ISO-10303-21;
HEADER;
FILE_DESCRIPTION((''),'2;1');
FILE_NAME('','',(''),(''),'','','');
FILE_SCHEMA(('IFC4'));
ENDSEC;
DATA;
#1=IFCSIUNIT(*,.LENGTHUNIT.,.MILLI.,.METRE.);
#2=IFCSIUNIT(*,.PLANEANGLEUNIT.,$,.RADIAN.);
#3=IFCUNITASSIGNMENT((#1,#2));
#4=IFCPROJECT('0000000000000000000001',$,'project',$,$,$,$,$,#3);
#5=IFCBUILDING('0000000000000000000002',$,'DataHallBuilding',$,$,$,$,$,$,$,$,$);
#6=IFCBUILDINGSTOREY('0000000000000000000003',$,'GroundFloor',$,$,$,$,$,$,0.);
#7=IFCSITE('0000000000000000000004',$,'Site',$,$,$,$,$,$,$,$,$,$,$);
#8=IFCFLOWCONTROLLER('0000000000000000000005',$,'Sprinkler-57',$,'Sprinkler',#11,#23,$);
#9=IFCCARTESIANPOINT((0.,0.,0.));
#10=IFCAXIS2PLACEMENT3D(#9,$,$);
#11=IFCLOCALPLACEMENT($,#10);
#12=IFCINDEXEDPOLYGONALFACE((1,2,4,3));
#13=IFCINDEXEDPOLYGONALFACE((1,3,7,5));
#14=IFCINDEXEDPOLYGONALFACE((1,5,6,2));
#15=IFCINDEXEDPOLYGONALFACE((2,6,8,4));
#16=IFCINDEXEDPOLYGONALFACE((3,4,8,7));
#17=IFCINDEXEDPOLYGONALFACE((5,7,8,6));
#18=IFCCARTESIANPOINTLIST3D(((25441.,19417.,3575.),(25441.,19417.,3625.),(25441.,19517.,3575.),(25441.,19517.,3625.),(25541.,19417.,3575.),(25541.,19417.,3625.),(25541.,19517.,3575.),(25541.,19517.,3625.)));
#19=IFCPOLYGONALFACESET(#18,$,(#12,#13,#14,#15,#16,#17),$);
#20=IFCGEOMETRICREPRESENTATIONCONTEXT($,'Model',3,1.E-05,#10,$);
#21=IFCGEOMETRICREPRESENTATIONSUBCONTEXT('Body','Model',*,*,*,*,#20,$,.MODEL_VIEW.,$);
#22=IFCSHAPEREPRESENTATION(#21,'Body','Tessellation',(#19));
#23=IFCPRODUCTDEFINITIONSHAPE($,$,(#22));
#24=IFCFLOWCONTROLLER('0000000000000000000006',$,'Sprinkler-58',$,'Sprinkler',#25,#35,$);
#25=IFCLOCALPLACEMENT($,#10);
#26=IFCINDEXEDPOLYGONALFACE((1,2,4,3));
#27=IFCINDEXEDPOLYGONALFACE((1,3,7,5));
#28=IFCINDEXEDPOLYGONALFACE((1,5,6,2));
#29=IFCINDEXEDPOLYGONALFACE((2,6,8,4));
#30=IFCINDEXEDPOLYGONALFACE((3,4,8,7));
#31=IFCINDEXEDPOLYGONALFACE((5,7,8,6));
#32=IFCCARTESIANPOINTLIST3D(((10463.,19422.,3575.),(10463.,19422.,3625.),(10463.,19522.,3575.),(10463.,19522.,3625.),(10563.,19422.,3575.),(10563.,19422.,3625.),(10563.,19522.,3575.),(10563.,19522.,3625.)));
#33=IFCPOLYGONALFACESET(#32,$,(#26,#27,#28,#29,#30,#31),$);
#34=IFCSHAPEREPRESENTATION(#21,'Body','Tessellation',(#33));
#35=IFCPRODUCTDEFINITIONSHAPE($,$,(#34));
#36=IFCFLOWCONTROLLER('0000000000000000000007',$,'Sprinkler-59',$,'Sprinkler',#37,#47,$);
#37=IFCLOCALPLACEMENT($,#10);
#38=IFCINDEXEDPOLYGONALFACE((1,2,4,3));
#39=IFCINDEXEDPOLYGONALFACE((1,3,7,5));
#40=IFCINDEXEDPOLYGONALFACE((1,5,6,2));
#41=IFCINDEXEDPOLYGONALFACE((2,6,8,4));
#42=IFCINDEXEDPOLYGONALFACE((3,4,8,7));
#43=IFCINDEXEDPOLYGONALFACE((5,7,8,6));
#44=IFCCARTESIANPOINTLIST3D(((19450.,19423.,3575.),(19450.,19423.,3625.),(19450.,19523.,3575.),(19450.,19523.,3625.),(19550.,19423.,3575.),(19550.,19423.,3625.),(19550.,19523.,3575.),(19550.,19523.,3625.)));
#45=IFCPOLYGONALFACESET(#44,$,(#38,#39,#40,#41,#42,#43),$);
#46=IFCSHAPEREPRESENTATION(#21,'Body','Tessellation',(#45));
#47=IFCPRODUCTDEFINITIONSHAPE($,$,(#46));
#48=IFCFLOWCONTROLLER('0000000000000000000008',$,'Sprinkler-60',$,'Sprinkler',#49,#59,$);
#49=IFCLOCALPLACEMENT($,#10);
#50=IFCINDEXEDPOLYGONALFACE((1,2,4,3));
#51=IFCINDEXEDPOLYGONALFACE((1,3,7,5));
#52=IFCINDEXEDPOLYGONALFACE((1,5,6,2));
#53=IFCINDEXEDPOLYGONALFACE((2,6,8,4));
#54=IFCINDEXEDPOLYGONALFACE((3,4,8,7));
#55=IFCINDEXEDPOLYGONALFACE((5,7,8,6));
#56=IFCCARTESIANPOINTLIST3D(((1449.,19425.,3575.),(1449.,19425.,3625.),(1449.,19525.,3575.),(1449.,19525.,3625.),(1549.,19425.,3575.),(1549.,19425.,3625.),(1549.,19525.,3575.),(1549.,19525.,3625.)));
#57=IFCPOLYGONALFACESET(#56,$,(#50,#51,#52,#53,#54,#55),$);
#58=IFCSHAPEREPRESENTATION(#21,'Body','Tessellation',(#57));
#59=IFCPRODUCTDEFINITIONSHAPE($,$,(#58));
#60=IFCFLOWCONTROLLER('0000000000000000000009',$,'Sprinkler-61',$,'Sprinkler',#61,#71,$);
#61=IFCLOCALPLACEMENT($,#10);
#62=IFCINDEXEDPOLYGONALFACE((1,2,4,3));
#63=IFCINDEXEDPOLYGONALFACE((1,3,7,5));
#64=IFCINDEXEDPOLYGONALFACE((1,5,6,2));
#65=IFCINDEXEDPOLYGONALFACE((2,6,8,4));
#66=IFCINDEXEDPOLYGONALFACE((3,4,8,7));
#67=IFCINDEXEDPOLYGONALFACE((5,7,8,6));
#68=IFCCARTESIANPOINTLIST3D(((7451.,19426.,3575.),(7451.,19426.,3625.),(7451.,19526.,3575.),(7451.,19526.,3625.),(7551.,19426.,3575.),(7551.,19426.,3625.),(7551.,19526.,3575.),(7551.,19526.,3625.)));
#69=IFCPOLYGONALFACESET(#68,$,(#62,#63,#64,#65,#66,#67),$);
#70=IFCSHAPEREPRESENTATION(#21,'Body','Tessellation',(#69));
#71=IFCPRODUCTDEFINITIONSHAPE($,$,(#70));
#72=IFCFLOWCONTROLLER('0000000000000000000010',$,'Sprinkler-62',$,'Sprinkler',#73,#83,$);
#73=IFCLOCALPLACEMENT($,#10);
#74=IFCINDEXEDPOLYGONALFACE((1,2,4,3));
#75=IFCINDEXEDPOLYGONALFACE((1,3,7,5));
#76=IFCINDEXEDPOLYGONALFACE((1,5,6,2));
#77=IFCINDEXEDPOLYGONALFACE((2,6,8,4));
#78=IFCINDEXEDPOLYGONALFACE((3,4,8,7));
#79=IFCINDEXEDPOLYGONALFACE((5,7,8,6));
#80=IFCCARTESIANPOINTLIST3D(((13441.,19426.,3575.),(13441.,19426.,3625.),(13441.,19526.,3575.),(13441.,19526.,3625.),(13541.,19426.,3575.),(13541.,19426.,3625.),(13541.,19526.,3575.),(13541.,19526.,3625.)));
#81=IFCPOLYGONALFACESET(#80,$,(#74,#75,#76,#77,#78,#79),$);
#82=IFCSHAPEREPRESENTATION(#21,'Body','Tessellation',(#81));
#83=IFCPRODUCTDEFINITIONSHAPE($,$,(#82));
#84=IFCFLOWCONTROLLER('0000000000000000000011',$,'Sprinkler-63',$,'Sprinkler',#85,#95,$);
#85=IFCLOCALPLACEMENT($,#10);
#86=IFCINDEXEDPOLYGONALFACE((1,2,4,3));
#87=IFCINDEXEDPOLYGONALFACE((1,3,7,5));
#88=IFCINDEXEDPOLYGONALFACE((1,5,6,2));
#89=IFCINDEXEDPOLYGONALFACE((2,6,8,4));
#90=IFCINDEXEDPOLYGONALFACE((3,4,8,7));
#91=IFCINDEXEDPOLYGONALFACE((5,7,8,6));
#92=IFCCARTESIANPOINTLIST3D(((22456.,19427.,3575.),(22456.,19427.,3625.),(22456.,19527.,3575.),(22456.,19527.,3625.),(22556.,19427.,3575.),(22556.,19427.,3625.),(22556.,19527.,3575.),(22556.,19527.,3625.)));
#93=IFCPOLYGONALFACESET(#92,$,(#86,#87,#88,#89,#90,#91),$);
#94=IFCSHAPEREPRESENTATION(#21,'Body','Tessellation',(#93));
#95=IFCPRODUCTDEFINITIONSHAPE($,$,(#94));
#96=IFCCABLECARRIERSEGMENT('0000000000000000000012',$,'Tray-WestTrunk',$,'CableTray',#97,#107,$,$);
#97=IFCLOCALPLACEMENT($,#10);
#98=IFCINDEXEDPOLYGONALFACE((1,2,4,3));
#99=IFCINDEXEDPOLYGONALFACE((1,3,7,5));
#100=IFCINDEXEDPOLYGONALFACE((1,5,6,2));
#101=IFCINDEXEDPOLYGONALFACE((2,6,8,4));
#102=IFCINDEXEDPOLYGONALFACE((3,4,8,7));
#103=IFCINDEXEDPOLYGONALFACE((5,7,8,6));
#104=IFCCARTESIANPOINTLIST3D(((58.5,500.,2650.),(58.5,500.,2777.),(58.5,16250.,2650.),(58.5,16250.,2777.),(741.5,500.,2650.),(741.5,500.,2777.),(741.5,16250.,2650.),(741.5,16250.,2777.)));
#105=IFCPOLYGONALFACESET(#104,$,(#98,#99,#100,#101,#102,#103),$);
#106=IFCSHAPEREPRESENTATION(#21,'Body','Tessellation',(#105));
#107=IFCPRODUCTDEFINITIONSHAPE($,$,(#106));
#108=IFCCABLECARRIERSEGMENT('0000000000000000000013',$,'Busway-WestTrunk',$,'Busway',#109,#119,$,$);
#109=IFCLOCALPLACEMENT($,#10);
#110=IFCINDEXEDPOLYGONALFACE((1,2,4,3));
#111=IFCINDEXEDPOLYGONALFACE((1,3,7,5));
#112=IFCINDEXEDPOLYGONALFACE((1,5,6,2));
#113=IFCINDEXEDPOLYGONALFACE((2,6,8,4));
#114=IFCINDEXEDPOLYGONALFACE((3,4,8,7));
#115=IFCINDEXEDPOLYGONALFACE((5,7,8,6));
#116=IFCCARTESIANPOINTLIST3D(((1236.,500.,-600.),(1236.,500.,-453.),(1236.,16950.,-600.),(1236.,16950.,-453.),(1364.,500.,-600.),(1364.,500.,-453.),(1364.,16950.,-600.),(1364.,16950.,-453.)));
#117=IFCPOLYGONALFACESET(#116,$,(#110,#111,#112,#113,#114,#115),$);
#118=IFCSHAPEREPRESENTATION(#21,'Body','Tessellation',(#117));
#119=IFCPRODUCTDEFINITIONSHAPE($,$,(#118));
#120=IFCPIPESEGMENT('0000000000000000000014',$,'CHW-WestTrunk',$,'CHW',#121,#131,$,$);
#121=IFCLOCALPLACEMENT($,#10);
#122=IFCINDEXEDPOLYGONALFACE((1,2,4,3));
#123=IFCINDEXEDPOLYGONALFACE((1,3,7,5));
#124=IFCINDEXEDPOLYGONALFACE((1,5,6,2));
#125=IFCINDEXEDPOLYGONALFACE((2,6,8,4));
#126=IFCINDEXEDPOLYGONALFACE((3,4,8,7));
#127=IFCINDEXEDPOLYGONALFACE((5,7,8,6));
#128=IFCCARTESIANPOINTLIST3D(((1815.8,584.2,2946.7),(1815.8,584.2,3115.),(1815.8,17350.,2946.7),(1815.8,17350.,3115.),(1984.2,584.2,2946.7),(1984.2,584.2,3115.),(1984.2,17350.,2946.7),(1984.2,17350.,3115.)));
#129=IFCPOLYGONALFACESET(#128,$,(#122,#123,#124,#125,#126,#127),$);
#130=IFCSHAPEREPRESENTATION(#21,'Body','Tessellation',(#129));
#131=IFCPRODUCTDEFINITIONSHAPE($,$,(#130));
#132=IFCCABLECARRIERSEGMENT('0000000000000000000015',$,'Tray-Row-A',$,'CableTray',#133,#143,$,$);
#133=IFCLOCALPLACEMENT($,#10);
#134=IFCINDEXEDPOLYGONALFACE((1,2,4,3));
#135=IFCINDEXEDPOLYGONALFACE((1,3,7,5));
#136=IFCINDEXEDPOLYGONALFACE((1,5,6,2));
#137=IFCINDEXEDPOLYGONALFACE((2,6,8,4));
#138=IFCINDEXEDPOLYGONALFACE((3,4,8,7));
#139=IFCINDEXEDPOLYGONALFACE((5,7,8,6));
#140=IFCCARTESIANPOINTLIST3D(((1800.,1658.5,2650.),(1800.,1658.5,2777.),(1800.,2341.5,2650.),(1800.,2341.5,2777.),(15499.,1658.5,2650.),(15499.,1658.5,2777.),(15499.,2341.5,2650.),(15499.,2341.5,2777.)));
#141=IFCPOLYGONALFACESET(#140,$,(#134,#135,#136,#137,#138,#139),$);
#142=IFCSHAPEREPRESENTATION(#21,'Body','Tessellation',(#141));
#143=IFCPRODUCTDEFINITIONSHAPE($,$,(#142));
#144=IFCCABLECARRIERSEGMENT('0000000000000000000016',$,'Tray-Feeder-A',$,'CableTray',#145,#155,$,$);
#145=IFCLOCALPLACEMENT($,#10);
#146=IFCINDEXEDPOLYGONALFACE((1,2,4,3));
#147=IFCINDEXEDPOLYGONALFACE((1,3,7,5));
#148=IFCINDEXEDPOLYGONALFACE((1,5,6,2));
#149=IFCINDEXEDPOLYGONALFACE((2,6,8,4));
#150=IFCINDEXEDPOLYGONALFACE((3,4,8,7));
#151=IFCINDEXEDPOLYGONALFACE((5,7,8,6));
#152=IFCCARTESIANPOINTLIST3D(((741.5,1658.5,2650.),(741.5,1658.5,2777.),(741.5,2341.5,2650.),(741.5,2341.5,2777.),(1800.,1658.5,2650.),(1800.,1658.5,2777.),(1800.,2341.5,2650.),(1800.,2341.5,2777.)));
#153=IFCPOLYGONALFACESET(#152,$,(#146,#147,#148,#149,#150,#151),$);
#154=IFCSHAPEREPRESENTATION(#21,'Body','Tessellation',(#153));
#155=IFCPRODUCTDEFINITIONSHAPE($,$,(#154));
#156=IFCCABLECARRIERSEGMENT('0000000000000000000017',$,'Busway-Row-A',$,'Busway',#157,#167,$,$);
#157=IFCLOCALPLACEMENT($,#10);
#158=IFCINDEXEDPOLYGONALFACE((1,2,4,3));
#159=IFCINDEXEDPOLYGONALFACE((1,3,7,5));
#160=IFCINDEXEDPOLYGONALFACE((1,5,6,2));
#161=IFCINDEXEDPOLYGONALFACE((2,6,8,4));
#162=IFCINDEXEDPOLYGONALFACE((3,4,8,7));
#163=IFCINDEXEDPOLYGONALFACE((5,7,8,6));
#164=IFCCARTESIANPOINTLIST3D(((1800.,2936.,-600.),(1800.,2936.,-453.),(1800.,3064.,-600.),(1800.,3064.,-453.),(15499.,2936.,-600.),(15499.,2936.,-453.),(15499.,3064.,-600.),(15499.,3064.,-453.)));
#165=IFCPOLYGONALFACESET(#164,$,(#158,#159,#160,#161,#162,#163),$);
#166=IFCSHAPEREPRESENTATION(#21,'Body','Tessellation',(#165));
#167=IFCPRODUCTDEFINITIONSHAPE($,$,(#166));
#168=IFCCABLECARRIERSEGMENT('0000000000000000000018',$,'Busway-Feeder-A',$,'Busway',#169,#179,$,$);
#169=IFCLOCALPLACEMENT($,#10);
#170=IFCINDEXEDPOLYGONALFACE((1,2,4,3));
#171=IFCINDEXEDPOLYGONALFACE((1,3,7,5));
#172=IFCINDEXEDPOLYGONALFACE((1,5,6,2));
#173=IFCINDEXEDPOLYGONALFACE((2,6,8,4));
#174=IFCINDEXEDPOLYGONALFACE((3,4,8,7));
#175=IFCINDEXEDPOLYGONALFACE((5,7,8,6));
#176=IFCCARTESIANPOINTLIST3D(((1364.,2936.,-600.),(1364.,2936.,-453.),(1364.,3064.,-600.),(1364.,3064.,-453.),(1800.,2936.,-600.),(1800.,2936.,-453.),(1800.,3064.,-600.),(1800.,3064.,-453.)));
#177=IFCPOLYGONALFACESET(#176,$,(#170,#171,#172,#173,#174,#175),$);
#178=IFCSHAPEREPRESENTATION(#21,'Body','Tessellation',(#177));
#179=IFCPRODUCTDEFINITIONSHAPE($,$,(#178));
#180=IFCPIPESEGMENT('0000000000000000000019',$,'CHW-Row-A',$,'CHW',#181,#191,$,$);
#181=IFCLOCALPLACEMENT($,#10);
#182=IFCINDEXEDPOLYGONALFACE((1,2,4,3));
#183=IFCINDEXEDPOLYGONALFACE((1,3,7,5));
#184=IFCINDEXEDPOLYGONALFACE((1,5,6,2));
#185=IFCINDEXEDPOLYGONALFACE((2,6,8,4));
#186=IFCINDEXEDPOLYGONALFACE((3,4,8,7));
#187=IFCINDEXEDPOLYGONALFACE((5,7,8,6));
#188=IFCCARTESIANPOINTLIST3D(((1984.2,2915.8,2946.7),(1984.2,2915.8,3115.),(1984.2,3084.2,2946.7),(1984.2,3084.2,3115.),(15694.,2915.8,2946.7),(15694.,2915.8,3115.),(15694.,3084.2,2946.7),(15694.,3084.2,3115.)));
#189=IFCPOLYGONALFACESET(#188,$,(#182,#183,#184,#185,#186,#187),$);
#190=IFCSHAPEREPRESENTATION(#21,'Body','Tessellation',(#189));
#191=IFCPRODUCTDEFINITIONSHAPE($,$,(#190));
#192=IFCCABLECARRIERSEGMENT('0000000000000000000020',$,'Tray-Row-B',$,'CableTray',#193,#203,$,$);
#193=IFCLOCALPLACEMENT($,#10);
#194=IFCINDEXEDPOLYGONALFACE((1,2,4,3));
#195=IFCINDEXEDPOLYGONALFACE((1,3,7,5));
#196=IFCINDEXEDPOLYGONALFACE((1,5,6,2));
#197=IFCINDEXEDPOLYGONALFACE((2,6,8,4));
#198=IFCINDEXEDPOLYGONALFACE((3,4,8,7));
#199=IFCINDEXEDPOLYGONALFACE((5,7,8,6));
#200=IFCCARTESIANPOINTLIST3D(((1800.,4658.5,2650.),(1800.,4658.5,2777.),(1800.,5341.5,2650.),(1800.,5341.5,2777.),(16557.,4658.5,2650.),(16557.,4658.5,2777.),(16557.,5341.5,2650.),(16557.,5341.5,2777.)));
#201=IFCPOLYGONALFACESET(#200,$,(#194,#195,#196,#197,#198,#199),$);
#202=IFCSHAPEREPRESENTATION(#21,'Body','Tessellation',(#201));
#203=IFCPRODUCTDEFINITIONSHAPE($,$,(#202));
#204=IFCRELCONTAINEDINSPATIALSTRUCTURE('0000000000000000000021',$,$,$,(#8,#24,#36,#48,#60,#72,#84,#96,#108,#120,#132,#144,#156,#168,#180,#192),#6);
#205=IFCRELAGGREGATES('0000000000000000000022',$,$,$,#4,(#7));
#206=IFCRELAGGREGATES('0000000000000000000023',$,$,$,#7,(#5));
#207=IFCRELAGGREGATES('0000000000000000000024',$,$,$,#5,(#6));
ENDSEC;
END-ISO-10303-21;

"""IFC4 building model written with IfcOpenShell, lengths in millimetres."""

from ifc_helpers import new_model, si_unit, frame, origin, place, context, subcontext, project, spatial, rectangle, extrude, element, save


model = new_model("IFC4")

# Units and contexts
model_context = context("Model", 3, precision=1e-05, world=origin())
body_context = subcontext(model_context, "Body", "Model", "MODEL_VIEW")
ifc_project = project(units=[si_unit("LENGTHUNIT", "METRE", prefix="MILLI"), si_unit("PLANEANGLEUNIT", "RADIAN")])

# Site, building, storey
site = spatial("IfcSite", under=ifc_project, Name="Site")
building = spatial("IfcBuilding", under=site, Name="DataHallBuilding")
storey = spatial("IfcBuildingStorey", under=building, Name="GroundFloor", Elevation=0.0)

# Flow controllers
flow_controller_1_placement = place(None, origin())
element("IfcFlowController", 1, at=flow_controller_1_placement, inside=storey, Name="Sprinkler-57", ObjectType="Sprinkler", context=body_context, shape_type="SweptSolid", body=[
    extrude(rectangle(XDim=100.0, YDim=100.0), frame((25491.0, 19467.0, 3575.0), z_axis=(0.0, 0.0, 1.0), x_axis=(1.0, 0.0, 0.0)), (0.0, 0.0, 1.0), 50.0),
])
flow_controller_2_placement = place(None, origin())
element("IfcFlowController", 2, at=flow_controller_2_placement, inside=storey, Name="Sprinkler-58", ObjectType="Sprinkler", context=body_context, shape_type="SweptSolid", body=[
    extrude(rectangle(XDim=100.0, YDim=100.0), frame((10513.0, 19472.0, 3575.0), z_axis=(0.0, 0.0, 1.0), x_axis=(1.0, 0.0, 0.0)), (0.0, 0.0, 1.0), 50.0),
])
flow_controller_3_placement = place(None, origin())
element("IfcFlowController", 3, at=flow_controller_3_placement, inside=storey, Name="Sprinkler-59", ObjectType="Sprinkler", context=body_context, shape_type="SweptSolid", body=[
    extrude(rectangle(XDim=100.0, YDim=100.0), frame((19500.0, 19473.0, 3575.0), z_axis=(0.0, 0.0, 1.0), x_axis=(1.0, 0.0, 0.0)), (0.0, 0.0, 1.0), 50.0),
])
flow_controller_4_placement = place(None, origin())
element("IfcFlowController", 4, at=flow_controller_4_placement, inside=storey, Name="Sprinkler-60", ObjectType="Sprinkler", context=body_context, shape_type="SweptSolid", body=[
    extrude(rectangle(XDim=100.0, YDim=100.0), frame((1499.0, 19475.0, 3575.0), z_axis=(0.0, 0.0, 1.0), x_axis=(1.0, 0.0, 0.0)), (0.0, 0.0, 1.0), 50.0),
])
flow_controller_5_placement = place(None, origin())
element("IfcFlowController", 5, at=flow_controller_5_placement, inside=storey, Name="Sprinkler-61", ObjectType="Sprinkler", context=body_context, shape_type="SweptSolid", body=[
    extrude(rectangle(XDim=100.0, YDim=100.0), frame((7501.0, 19476.0, 3575.0), z_axis=(0.0, 0.0, 1.0), x_axis=(1.0, 0.0, 0.0)), (0.0, 0.0, 1.0), 50.0),
])
flow_controller_6_placement = place(None, origin())
element("IfcFlowController", 6, at=flow_controller_6_placement, inside=storey, Name="Sprinkler-62", ObjectType="Sprinkler", context=body_context, shape_type="SweptSolid", body=[
    extrude(rectangle(XDim=100.0, YDim=100.0), frame((13491.0, 19476.0, 3575.0), z_axis=(0.0, 0.0, 1.0), x_axis=(1.0, 0.0, 0.0)), (0.0, 0.0, 1.0), 50.0),
])
flow_controller_7_placement = place(None, origin())
element("IfcFlowController", 7, at=flow_controller_7_placement, inside=storey, Name="Sprinkler-63", ObjectType="Sprinkler", context=body_context, shape_type="SweptSolid", body=[
    extrude(rectangle(XDim=100.0, YDim=100.0), frame((22506.0, 19477.0, 3575.0), z_axis=(0.0, 0.0, 1.0), x_axis=(1.0, 0.0, 0.0)), (0.0, 0.0, 1.0), 50.0),
])

# Cable carrier segments
cable_carrier_segment_1_placement = place(None, origin())
element("IfcCableCarrierSegment", 8, at=cable_carrier_segment_1_placement, inside=storey, Name="Tray-WestTrunk", ObjectType="CableTray", context=body_context, shape_type="SweptSolid", body=[
    extrude(rectangle(XDim=683.0, YDim=15750.0), frame((400.0, 8375.0, 2650.0), z_axis=(0.0, 0.0, 1.0), x_axis=(1.0, 0.0, 0.0)), (0.0, 0.0, 1.0), 127.0),
])
cable_carrier_segment_2_placement = place(None, origin())
element("IfcCableCarrierSegment", 9, at=cable_carrier_segment_2_placement, inside=storey, Name="Busway-WestTrunk", ObjectType="Busway", context=body_context, shape_type="SweptSolid", body=[
    extrude(rectangle(XDim=128.0, YDim=16450.0), frame((1300.0, 8725.0, -600.0), z_axis=(0.0, 0.0, 1.0), x_axis=(1.0, 0.0, 0.0)), (0.0, 0.0, 1.0), 147.0),
])

# Pipe segment
pipe_segment_1_placement = place(None, origin())
element("IfcPipeSegment", 10, at=pipe_segment_1_placement, inside=storey, Name="CHW-WestTrunk", ObjectType="CHW", context=body_context, shape_type="SweptSolid", body=[
    extrude(rectangle(XDim=168.3, YDim=16765.8), frame((1900.0, 8967.1, 2946.7), z_axis=(0.0, 0.0, 1.0), x_axis=(1.0, 0.0, 0.0)), (0.0, 0.0, 1.0), 168.3),
])

# Cable carrier segments
cable_carrier_segment_3_placement = place(None, origin())
element("IfcCableCarrierSegment", 11, at=cable_carrier_segment_3_placement, inside=storey, Name="Tray-Row-A", ObjectType="CableTray", context=body_context, shape_type="SweptSolid", body=[
    extrude(rectangle(XDim=13699.0, YDim=683.0), frame((8649.5, 2000.0, 2650.0), z_axis=(0.0, 0.0, 1.0), x_axis=(1.0, 0.0, 0.0)), (0.0, 0.0, 1.0), 127.0),
])
cable_carrier_segment_4_placement = place(None, origin())
element("IfcCableCarrierSegment", 12, at=cable_carrier_segment_4_placement, inside=storey, Name="Tray-Feeder-A", ObjectType="CableTray", context=body_context, shape_type="SweptSolid", body=[
    extrude(rectangle(XDim=1058.5, YDim=683.0), frame((1270.8, 2000.0, 2650.0), z_axis=(0.0, 0.0, 1.0), x_axis=(1.0, 0.0, 0.0)), (0.0, 0.0, 1.0), 127.0),
])
cable_carrier_segment_5_placement = place(None, origin())
element("IfcCableCarrierSegment", 13, at=cable_carrier_segment_5_placement, inside=storey, Name="Busway-Row-A", ObjectType="Busway", context=body_context, shape_type="SweptSolid", body=[
    extrude(rectangle(XDim=13699.0, YDim=128.0), frame((8649.5, 3000.0, -600.0), z_axis=(0.0, 0.0, 1.0), x_axis=(1.0, 0.0, 0.0)), (0.0, 0.0, 1.0), 147.0),
])
cable_carrier_segment_6_placement = place(None, origin())
element("IfcCableCarrierSegment", 14, at=cable_carrier_segment_6_placement, inside=storey, Name="Busway-Feeder-A", ObjectType="Busway", context=body_context, shape_type="SweptSolid", body=[
    extrude(rectangle(XDim=436.0, YDim=128.0), frame((1582.0, 3000.0, -600.0), z_axis=(0.0, 0.0, 1.0), x_axis=(1.0, 0.0, 0.0)), (0.0, 0.0, 1.0), 147.0),
])

# Pipe segment
pipe_segment_2_placement = place(None, origin())
element("IfcPipeSegment", 15, at=pipe_segment_2_placement, inside=storey, Name="CHW-Row-A", ObjectType="CHW", context=body_context, shape_type="SweptSolid", body=[
    extrude(rectangle(XDim=13709.9, YDim=168.3), frame((8839.1, 3000.0, 2946.7), z_axis=(0.0, 0.0, 1.0), x_axis=(1.0, 0.0, 0.0)), (0.0, 0.0, 1.0), 168.3),
])

# Cable carrier segment
cable_carrier_segment_7_placement = place(None, origin())
element("IfcCableCarrierSegment", 16, at=cable_carrier_segment_7_placement, inside=storey, Name="Tray-Row-B", ObjectType="CableTray", context=body_context, shape_type="SweptSolid", body=[
    extrude(rectangle(XDim=14757.0, YDim=683.0), frame((9178.5, 5000.0, 2650.0), z_axis=(0.0, 0.0, 1.0), x_axis=(1.0, 0.0, 0.0)), (0.0, 0.0, 1.0), 127.0),
])

save(model, "model.ifc")
